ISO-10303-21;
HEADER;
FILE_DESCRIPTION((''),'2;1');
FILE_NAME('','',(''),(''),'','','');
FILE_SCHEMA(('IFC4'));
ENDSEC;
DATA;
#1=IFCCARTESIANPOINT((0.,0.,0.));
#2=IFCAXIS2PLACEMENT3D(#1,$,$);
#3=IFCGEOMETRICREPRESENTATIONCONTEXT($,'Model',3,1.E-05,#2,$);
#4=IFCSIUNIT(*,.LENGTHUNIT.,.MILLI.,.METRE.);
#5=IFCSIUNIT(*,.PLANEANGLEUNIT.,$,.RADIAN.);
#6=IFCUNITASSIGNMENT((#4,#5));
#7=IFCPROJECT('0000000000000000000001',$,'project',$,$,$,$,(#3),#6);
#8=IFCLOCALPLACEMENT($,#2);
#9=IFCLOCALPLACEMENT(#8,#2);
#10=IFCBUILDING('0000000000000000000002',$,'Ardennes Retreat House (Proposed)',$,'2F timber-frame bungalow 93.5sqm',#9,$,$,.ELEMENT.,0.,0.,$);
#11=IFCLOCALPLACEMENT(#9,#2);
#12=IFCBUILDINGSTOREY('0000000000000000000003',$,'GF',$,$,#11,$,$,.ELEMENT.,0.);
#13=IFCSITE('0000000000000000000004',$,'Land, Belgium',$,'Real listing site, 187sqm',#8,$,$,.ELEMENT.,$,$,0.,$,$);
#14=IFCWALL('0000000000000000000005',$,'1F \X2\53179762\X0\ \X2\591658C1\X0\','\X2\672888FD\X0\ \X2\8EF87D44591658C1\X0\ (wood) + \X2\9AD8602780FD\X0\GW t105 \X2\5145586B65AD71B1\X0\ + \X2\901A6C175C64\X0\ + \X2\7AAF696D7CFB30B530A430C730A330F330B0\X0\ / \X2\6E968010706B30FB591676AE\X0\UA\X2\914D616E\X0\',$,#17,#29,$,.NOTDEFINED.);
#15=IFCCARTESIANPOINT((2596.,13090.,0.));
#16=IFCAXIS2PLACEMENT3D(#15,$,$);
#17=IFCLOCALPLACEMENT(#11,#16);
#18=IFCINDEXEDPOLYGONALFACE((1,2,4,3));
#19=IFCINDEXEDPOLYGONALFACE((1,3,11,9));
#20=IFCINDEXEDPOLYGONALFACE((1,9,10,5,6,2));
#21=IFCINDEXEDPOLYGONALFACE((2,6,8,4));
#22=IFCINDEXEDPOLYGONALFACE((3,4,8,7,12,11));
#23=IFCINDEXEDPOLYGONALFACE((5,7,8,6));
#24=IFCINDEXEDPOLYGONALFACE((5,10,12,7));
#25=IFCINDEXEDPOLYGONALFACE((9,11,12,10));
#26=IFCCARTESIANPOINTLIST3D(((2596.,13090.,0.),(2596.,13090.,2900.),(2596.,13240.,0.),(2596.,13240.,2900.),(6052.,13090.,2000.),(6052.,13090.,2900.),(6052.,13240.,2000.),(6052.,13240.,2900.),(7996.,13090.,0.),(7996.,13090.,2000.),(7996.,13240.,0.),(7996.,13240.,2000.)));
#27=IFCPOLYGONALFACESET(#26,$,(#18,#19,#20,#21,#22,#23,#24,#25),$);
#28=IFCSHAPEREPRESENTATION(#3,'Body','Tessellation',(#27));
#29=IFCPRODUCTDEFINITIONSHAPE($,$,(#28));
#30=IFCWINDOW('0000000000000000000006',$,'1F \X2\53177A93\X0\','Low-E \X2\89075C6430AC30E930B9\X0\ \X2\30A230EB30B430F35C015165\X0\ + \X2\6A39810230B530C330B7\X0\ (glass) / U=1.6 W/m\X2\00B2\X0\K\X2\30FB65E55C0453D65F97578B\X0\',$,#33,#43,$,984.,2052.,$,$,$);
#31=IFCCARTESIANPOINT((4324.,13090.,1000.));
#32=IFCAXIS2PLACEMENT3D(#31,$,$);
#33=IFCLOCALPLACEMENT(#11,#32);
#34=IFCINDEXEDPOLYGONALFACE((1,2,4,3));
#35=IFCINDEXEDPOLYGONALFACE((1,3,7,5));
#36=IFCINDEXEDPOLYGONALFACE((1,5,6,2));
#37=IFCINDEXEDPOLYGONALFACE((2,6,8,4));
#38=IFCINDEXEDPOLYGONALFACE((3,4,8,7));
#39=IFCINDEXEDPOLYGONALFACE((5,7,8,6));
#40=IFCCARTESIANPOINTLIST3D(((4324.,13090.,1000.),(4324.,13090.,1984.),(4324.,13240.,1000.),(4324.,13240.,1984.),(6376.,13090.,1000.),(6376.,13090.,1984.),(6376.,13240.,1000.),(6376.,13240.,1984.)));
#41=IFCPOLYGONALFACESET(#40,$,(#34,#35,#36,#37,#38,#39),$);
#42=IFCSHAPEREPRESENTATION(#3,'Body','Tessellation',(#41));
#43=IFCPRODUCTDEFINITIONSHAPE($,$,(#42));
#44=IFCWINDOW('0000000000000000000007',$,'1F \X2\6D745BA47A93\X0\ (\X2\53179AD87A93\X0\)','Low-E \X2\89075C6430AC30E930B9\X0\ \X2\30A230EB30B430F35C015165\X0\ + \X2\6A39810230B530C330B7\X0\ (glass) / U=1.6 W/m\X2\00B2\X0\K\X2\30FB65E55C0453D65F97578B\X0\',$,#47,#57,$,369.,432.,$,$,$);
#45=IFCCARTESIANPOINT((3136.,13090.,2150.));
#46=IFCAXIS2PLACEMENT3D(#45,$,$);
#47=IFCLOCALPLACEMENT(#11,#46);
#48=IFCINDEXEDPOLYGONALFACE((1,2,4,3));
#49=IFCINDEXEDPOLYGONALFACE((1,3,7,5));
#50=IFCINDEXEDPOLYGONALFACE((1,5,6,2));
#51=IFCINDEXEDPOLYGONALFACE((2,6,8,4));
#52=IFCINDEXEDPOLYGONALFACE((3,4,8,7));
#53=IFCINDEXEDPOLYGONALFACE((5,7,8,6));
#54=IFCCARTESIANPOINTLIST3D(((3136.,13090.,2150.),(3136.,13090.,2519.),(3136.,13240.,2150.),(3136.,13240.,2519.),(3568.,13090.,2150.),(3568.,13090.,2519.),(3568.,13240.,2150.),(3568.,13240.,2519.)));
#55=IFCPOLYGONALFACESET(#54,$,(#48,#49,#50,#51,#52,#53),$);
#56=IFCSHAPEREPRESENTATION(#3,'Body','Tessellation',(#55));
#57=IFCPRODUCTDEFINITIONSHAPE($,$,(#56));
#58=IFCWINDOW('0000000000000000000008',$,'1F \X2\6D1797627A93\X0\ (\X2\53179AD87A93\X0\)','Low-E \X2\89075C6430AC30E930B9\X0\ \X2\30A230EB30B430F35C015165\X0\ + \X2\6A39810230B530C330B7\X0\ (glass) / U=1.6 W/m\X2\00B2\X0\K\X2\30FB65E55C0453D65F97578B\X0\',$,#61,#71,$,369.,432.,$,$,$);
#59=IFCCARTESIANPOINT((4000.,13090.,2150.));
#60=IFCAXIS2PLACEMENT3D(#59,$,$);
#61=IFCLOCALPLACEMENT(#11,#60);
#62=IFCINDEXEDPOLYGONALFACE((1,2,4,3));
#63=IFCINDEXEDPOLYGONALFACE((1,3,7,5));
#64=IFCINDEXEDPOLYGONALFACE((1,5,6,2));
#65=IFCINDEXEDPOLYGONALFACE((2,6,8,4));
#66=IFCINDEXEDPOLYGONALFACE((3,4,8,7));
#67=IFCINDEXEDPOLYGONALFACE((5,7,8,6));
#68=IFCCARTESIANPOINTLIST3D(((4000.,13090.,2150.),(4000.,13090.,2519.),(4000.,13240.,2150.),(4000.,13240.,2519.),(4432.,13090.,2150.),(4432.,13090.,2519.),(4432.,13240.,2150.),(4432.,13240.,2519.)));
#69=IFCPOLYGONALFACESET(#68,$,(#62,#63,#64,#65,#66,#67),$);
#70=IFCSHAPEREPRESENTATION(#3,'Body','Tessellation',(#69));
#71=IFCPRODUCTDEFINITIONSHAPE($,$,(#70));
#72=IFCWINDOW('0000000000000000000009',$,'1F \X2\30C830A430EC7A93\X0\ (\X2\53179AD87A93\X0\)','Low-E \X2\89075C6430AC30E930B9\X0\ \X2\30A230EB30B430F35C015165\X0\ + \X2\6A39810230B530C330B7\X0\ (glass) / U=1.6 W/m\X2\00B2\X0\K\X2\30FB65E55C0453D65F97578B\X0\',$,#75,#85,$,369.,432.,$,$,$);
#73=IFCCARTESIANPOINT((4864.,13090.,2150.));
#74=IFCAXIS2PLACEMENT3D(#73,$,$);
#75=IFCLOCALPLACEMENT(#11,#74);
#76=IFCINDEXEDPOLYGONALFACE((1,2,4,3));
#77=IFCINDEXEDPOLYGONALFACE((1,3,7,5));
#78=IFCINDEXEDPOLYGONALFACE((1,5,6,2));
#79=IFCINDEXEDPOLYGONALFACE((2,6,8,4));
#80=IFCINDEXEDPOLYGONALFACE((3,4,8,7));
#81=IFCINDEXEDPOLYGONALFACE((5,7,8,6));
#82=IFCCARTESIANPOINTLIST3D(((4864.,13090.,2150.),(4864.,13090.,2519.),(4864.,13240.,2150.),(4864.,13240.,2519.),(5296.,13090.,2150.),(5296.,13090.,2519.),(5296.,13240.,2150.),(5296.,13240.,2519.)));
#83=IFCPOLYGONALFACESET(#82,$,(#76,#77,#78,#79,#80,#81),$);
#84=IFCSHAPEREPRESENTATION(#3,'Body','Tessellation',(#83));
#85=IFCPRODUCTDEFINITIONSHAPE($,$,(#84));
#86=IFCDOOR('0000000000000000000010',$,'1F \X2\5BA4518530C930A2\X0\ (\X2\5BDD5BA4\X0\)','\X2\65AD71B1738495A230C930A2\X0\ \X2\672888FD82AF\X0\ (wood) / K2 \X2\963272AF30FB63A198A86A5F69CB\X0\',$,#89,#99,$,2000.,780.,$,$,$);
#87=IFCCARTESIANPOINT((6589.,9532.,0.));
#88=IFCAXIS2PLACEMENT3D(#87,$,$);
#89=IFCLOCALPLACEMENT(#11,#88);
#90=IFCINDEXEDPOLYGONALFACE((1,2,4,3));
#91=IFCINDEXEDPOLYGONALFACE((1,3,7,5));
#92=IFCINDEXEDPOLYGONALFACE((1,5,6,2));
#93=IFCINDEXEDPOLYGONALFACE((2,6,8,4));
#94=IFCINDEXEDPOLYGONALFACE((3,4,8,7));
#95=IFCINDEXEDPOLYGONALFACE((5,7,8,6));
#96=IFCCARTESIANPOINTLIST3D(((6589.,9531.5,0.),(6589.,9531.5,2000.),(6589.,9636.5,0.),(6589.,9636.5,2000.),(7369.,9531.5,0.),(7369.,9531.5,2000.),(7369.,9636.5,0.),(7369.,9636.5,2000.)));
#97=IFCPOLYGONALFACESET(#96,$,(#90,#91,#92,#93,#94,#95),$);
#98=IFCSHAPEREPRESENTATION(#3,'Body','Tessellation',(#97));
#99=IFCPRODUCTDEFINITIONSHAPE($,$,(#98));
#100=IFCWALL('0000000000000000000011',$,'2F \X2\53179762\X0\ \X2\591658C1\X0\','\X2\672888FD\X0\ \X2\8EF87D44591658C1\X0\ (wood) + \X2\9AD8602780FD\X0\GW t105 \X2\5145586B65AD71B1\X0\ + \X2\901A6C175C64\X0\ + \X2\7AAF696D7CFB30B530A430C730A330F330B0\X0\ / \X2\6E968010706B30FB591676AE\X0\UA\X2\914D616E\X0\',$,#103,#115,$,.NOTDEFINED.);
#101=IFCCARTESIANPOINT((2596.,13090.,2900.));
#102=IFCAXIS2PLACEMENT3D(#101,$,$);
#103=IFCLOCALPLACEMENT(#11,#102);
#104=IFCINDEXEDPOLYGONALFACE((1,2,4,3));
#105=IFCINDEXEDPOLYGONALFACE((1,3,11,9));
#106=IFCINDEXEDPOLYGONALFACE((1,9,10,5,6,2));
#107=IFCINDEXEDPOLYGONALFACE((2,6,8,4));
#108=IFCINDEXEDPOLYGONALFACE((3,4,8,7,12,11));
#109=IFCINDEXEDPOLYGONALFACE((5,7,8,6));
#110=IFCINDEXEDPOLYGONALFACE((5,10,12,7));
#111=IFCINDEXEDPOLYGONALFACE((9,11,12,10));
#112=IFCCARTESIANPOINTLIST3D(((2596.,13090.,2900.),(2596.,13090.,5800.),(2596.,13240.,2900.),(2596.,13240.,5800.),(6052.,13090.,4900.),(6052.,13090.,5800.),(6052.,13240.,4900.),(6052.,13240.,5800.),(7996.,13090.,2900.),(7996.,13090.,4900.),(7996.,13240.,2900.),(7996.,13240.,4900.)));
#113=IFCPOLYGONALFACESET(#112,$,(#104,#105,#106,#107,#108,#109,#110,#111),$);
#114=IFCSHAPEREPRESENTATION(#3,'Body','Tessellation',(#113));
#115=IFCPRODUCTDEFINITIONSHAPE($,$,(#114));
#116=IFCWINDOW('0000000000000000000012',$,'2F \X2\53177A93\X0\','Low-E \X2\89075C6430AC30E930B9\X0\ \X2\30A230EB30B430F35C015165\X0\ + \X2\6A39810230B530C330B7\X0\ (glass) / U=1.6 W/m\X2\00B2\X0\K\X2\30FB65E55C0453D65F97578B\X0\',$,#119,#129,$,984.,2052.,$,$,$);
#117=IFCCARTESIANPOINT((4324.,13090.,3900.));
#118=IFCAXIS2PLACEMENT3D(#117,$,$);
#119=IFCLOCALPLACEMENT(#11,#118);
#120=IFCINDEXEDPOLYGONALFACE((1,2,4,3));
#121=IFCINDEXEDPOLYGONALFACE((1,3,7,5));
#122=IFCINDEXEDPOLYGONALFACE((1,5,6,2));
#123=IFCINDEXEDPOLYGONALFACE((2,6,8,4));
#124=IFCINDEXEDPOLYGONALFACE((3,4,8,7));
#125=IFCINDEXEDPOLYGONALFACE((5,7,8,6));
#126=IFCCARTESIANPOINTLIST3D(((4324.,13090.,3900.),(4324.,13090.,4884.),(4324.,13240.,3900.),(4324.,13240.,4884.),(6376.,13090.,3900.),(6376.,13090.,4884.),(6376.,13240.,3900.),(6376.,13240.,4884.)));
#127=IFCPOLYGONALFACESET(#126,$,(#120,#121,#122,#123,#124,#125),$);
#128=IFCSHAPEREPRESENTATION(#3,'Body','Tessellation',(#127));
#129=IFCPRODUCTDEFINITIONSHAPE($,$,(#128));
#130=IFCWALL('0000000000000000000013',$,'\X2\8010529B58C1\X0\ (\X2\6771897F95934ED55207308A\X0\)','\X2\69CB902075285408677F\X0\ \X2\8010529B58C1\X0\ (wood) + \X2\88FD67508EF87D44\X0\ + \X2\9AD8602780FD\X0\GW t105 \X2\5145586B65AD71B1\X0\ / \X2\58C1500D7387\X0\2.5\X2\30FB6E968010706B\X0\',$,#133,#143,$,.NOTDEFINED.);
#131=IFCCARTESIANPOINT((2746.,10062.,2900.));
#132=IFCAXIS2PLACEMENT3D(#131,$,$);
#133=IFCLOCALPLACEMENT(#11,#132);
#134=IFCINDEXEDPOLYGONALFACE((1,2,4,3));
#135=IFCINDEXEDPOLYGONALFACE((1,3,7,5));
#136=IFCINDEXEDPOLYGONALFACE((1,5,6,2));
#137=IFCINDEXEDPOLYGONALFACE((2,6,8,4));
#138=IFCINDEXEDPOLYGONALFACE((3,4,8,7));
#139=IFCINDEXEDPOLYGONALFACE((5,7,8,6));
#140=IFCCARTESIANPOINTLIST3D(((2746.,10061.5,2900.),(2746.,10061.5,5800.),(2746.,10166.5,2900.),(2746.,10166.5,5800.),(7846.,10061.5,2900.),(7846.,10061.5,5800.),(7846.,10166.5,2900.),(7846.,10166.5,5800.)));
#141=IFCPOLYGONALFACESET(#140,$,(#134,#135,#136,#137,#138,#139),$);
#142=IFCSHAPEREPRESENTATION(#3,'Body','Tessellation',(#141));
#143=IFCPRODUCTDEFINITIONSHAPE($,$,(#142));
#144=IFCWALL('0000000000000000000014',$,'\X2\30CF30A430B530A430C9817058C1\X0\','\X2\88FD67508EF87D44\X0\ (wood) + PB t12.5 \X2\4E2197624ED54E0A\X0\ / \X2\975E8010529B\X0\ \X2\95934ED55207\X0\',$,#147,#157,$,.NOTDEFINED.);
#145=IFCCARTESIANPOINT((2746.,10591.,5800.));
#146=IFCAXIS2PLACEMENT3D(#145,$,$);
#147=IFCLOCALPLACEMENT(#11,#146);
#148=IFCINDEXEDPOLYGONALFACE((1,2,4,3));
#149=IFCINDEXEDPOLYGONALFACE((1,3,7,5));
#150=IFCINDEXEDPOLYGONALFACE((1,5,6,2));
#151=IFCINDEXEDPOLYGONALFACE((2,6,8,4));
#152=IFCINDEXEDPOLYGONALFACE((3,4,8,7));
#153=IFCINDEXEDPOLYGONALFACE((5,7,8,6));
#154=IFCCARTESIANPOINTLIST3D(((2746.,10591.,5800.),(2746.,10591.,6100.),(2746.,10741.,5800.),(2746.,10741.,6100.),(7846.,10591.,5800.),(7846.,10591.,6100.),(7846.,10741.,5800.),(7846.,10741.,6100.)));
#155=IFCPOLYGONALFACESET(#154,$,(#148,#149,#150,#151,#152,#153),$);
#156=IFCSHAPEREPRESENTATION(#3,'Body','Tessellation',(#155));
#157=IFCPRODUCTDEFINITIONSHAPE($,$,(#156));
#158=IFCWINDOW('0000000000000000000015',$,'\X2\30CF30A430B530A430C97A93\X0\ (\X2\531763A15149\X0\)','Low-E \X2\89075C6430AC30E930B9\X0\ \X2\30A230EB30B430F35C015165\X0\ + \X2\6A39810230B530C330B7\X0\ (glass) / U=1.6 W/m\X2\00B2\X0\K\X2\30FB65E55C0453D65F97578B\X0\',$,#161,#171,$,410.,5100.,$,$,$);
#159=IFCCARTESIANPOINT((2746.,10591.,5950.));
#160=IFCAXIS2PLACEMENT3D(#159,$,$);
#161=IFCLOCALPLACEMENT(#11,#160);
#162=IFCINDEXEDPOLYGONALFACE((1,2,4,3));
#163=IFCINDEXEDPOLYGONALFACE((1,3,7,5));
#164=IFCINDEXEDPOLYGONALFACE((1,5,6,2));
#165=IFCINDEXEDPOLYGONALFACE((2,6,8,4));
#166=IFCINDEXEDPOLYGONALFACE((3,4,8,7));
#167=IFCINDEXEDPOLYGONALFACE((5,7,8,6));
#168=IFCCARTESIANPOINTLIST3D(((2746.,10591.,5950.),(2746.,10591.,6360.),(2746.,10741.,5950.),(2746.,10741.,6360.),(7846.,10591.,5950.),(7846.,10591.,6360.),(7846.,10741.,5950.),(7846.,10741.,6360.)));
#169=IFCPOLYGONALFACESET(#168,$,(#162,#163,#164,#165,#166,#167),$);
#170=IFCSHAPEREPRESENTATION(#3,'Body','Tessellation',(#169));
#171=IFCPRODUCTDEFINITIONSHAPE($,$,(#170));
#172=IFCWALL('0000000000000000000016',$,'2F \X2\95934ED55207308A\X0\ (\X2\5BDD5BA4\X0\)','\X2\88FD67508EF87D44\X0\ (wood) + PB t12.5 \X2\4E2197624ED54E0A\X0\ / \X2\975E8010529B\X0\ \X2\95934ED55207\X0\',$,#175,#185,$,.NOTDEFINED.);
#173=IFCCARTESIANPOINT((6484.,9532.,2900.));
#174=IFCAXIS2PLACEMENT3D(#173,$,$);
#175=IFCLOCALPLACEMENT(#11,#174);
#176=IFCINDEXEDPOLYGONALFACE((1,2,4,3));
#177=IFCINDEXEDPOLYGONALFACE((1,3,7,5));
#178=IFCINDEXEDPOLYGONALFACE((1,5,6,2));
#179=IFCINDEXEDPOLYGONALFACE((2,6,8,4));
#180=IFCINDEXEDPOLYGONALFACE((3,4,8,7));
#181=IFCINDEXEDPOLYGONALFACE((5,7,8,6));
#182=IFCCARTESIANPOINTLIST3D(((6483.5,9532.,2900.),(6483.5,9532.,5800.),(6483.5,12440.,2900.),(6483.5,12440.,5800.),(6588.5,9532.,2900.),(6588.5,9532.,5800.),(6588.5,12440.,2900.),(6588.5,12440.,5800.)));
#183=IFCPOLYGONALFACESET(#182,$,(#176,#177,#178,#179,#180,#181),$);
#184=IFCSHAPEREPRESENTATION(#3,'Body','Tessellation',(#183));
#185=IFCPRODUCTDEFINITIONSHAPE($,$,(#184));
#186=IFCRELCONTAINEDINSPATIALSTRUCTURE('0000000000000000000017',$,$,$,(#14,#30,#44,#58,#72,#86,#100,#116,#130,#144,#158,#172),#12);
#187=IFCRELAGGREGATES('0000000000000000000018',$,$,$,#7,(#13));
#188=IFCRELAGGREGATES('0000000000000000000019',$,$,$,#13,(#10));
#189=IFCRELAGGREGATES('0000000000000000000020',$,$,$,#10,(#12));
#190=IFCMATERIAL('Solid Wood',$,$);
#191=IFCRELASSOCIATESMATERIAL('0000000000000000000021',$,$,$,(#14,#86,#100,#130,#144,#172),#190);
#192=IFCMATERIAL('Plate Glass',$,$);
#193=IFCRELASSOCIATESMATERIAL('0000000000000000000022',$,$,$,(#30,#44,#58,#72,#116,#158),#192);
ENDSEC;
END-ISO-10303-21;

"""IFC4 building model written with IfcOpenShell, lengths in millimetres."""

from ifc_helpers import new_model, si_unit, frame, frame_2d, origin, place, context, project, spatial, rectangle, extrude, material, element, fill, save


model = new_model("IFC4")

# Units and contexts
model_context = context("Model", 3, precision=1e-05, world=origin())
ifc_project = project(units=[si_unit("LENGTHUNIT", "METRE", prefix="MILLI"), si_unit("PLANEANGLEUNIT", "RADIAN")], contexts=[model_context])

# Site, building, storey
site_placement = place(None, origin())
site = spatial("IfcSite", under=ifc_project, at=site_placement, Name="Land, Belgium", ObjectType="Real listing site, 187sqm", CompositionType="ELEMENT", RefElevation=0.0)
building_placement = place(site_placement, origin())
building = spatial("IfcBuilding", under=site, at=building_placement, Name="Ardennes Retreat House (Proposed)", ObjectType="2F timber-frame bungalow 93.5sqm", CompositionType="ELEMENT", ElevationOfRefHeight=0.0, ElevationOfTerrain=0.0)
storey_placement = place(building_placement, origin())
storey = spatial("IfcBuildingStorey", under=building, at=storey_placement, Name="GF", CompositionType="ELEMENT", Elevation=0.0)

# Wall, openings, windows
ifc_material_1 = material(Name="Solid Wood")
wall_1_placement = place(storey_placement, frame((2596.0, 13090.0, 0.0)))
wall_1 = element("IfcWall", 1, at=wall_1_placement, inside=storey, material=ifc_material_1, Name="1F 北面 外壁", Description="木製 軸組外壁 (wood) + 高性能GW t105 充填断熱 + 通気層 + 窯業系サイディング / 準耐火・外皮UA配慮", PredefinedType="NOTDEFINED", context=model_context, shape_type="SweptSolid", body=[
    extrude(rectangle(XDim=5400.0, YDim=150.0, at=frame_2d((2700.0, 75.0))), frame((2596.0, 13090.0, 0.0)), (0.0, 0.0, 1.0), 2900.0),
])
opening_1_placement = place(storey_placement, frame((4324.0, 13090.0, 1000.0)))
opening_1 = element("IfcOpeningElement", 2, at=opening_1_placement, cuts=wall_1, PredefinedType="NOTDEFINED", context=model_context, shape_type="SweptSolid", body=[
    extrude(rectangle(XDim=2052.0, YDim=150.0, at=frame_2d((1026.0, 75.0))), frame((4324.0, 13090.0, 1000.0)), (0.0, 0.0, 1.0), 984.0),
])
opening_2_placement = place(storey_placement, frame((3136.0, 13090.0, 2150.0)))
opening_2 = element("IfcOpeningElement", 3, at=opening_2_placement, cuts=wall_1, PredefinedType="NOTDEFINED", context=model_context, shape_type="SweptSolid", body=[
    extrude(rectangle(XDim=432.0, YDim=150.0, at=frame_2d((216.0, 75.0))), frame((3136.0, 13090.0, 2150.0)), (0.0, 0.0, 1.0), 369.0),
])
opening_3_placement = place(storey_placement, frame((4000.0, 13090.0, 2150.0)))
opening_3 = element("IfcOpeningElement", 4, at=opening_3_placement, cuts=wall_1, PredefinedType="NOTDEFINED", context=model_context, shape_type="SweptSolid", body=[
    extrude(rectangle(XDim=432.0, YDim=150.0, at=frame_2d((216.0, 75.0))), frame((4000.0, 13090.0, 2150.0)), (0.0, 0.0, 1.0), 369.0),
])
opening_4_placement = place(storey_placement, frame((4864.0, 13090.0, 2150.0)))
opening_4 = element("IfcOpeningElement", 5, at=opening_4_placement, cuts=wall_1, PredefinedType="NOTDEFINED", context=model_context, shape_type="SweptSolid", body=[
    extrude(rectangle(XDim=432.0, YDim=150.0, at=frame_2d((216.0, 75.0))), frame((4864.0, 13090.0, 2150.0)), (0.0, 0.0, 1.0), 369.0),
])
ifc_material_2 = material(Name="Plate Glass")
window_1_placement = place(storey_placement, frame((4324.0, 13090.0, 1000.0)))
window_1 = element("IfcWindow", 6, at=window_1_placement, inside=storey, material=ifc_material_2, Name="1F 北窓", Description="Low-E 複層ガラス アルゴン封入 + 樹脂サッシ (glass) / U=1.6 W/m²K・日射取得型", OverallHeight=984.0, OverallWidth=2052.0, context=model_context, shape_type="SweptSolid", body=[
    extrude(rectangle(XDim=2052.0, YDim=150.0, at=frame_2d((1026.0, 75.0))), frame((4324.0, 13090.0, 1000.0)), (0.0, 0.0, 1.0), 984.0),
])
fill(opening_1, window_1)
window_2_placement = place(storey_placement, frame((3136.0, 13090.0, 2150.0)))
window_2 = element("IfcWindow", 7, at=window_2_placement, inside=storey, material=ifc_material_2, Name="1F 浴室窓 (北高窓)", Description="Low-E 複層ガラス アルゴン封入 + 樹脂サッシ (glass) / U=1.6 W/m²K・日射取得型", OverallHeight=369.0, OverallWidth=432.0, context=model_context, shape_type="SweptSolid", body=[
    extrude(rectangle(XDim=432.0, YDim=150.0, at=frame_2d((216.0, 75.0))), frame((3136.0, 13090.0, 2150.0)), (0.0, 0.0, 1.0), 369.0),
])
fill(opening_2, window_2)
window_3_placement = place(storey_placement, frame((4000.0, 13090.0, 2150.0)))
window_3 = element("IfcWindow", 8, at=window_3_placement, inside=storey, material=ifc_material_2, Name="1F 洗面窓 (北高窓)", Description="Low-E 複層ガラス アルゴン封入 + 樹脂サッシ (glass) / U=1.6 W/m²K・日射取得型", OverallHeight=369.0, OverallWidth=432.0, context=model_context, shape_type="SweptSolid", body=[
    extrude(rectangle(XDim=432.0, YDim=150.0, at=frame_2d((216.0, 75.0))), frame((4000.0, 13090.0, 2150.0)), (0.0, 0.0, 1.0), 369.0),
])
fill(opening_3, window_3)
window_4_placement = place(storey_placement, frame((4864.0, 13090.0, 2150.0)))
window_4 = element("IfcWindow", 9, at=window_4_placement, inside=storey, material=ifc_material_2, Name="1F トイレ窓 (北高窓)", Description="Low-E 複層ガラス アルゴン封入 + 樹脂サッシ (glass) / U=1.6 W/m²K・日射取得型", OverallHeight=369.0, OverallWidth=432.0, context=model_context, shape_type="SweptSolid", body=[
    extrude(rectangle(XDim=432.0, YDim=150.0, at=frame_2d((216.0, 75.0))), frame((4864.0, 13090.0, 2150.0)), (0.0, 0.0, 1.0), 369.0),
])
fill(opening_4, window_4)

# Door
door_1_placement = place(storey_placement, frame((6589.0, 9532.0, 0.0)))
element("IfcDoor", 10, at=door_1_placement, inside=storey, material=ifc_material_1, Name="1F 室内ドア (寝室)", Description="断熱玄関ドア 木製芯 (wood) / K2 防犯・採風機構", OverallHeight=2000.0, OverallWidth=780.0, context=model_context, shape_type="SweptSolid", body=[
    extrude(rectangle(XDim=780.0, YDim=105.0, at=frame_2d((390.0, 52.0))), frame((6589.0, 9532.0, 0.0)), (0.0, 0.0, 1.0), 2000.0),
])

# Wall, opening, window
wall_2_placement = place(storey_placement, frame((2596.0, 13090.0, 2900.0)))
wall_2 = element("IfcWall", 11, at=wall_2_placement, inside=storey, material=ifc_material_1, Name="2F 北面 外壁", Description="木製 軸組外壁 (wood) + 高性能GW t105 充填断熱 + 通気層 + 窯業系サイディング / 準耐火・外皮UA配慮", PredefinedType="NOTDEFINED", context=model_context, shape_type="SweptSolid", body=[
    extrude(rectangle(XDim=5400.0, YDim=150.0, at=frame_2d((2700.0, 75.0))), frame((2596.0, 13090.0, 2900.0)), (0.0, 0.0, 1.0), 2900.0),
])
opening_5_placement = place(storey_placement, frame((4324.0, 13090.0, 3900.0)))
opening_5 = element("IfcOpeningElement", 12, at=opening_5_placement, cuts=wall_2, PredefinedType="NOTDEFINED", context=model_context, shape_type="SweptSolid", body=[
    extrude(rectangle(XDim=2052.0, YDim=150.0, at=frame_2d((1026.0, 75.0))), frame((4324.0, 13090.0, 3900.0)), (0.0, 0.0, 1.0), 984.0),
])
window_5_placement = place(storey_placement, frame((4324.0, 13090.0, 3900.0)))
window_5 = element("IfcWindow", 13, at=window_5_placement, inside=storey, material=ifc_material_2, Name="2F 北窓", Description="Low-E 複層ガラス アルゴン封入 + 樹脂サッシ (glass) / U=1.6 W/m²K・日射取得型", OverallHeight=984.0, OverallWidth=2052.0, context=model_context, shape_type="SweptSolid", body=[
    extrude(rectangle(XDim=2052.0, YDim=150.0, at=frame_2d((1026.0, 75.0))), frame((4324.0, 13090.0, 3900.0)), (0.0, 0.0, 1.0), 984.0),
])
fill(opening_5, window_5)

# Wall
wall_3_placement = place(storey_placement, frame((2746.0, 10062.0, 2900.0)))
element("IfcWall", 14, at=wall_3_placement, inside=storey, material=ifc_material_1, Name="耐力壁 (東西間仕切り)", Description="構造用合板 耐力壁 (wood) + 製材軸組 + 高性能GW t105 充填断熱 / 壁倍率2.5・準耐火", PredefinedType="NOTDEFINED", context=model_context, shape_type="SweptSolid", body=[
    extrude(rectangle(XDim=5100.0, YDim=105.0, at=frame_2d((2550.0, 52.0))), frame((2746.0, 10062.0, 2900.0)), (0.0, 0.0, 1.0), 2900.0),
])

# Wall, opening, window
wall_4_placement = place(storey_placement, frame((2746.0, 10591.0, 5800.0)))
wall_4 = element("IfcWall", 15, at=wall_4_placement, inside=storey, material=ifc_material_1, Name="ハイサイド腰壁", Description="製材軸組 (wood) + PB t12.5 両面仕上 / 非耐力 間仕切", PredefinedType="NOTDEFINED", context=model_context, shape_type="SweptSolid", body=[
    extrude(rectangle(XDim=5100.0, YDim=150.0, at=frame_2d((2550.0, 75.0))), frame((2746.0, 10591.0, 5800.0)), (0.0, 0.0, 1.0), 700.0),
])
opening_6_placement = place(storey_placement, frame((2746.0, 10591.0, 5950.0)))
opening_6 = element("IfcOpeningElement", 16, at=opening_6_placement, cuts=wall_4, PredefinedType="NOTDEFINED", context=model_context, shape_type="SweptSolid", body=[
    extrude(rectangle(XDim=5100.0, YDim=150.0, at=frame_2d((2550.0, 75.0))), frame((2746.0, 10591.0, 5950.0)), (0.0, 0.0, 1.0), 410.0),
])
window_6_placement = place(storey_placement, frame((2746.0, 10591.0, 5950.0)))
window_6 = element("IfcWindow", 17, at=window_6_placement, inside=storey, material=ifc_material_2, Name="ハイサイド窓 (北採光)", Description="Low-E 複層ガラス アルゴン封入 + 樹脂サッシ (glass) / U=1.6 W/m²K・日射取得型", OverallHeight=410.0, OverallWidth=5100.0, context=model_context, shape_type="SweptSolid", body=[
    extrude(rectangle(XDim=5100.0, YDim=150.0, at=frame_2d((2550.0, 75.0))), frame((2746.0, 10591.0, 5950.0)), (0.0, 0.0, 1.0), 410.0),
])
fill(opening_6, window_6)

# Wall
wall_5_placement = place(storey_placement, frame((6484.0, 9532.0, 2900.0)))
element("IfcWall", 18, at=wall_5_placement, inside=storey, material=ifc_material_1, Name="2F 間仕切り (寝室)", Description="製材軸組 (wood) + PB t12.5 両面仕上 / 非耐力 間仕切", PredefinedType="NOTDEFINED", context=model_context, shape_type="SweptSolid", body=[
    extrude(rectangle(XDim=105.0, YDim=2908.0, at=frame_2d((52.0, 1454.0))), frame((6484.0, 9532.0, 2900.0)), (0.0, 0.0, 1.0), 2900.0),
])

save(model, "model.ifc")
